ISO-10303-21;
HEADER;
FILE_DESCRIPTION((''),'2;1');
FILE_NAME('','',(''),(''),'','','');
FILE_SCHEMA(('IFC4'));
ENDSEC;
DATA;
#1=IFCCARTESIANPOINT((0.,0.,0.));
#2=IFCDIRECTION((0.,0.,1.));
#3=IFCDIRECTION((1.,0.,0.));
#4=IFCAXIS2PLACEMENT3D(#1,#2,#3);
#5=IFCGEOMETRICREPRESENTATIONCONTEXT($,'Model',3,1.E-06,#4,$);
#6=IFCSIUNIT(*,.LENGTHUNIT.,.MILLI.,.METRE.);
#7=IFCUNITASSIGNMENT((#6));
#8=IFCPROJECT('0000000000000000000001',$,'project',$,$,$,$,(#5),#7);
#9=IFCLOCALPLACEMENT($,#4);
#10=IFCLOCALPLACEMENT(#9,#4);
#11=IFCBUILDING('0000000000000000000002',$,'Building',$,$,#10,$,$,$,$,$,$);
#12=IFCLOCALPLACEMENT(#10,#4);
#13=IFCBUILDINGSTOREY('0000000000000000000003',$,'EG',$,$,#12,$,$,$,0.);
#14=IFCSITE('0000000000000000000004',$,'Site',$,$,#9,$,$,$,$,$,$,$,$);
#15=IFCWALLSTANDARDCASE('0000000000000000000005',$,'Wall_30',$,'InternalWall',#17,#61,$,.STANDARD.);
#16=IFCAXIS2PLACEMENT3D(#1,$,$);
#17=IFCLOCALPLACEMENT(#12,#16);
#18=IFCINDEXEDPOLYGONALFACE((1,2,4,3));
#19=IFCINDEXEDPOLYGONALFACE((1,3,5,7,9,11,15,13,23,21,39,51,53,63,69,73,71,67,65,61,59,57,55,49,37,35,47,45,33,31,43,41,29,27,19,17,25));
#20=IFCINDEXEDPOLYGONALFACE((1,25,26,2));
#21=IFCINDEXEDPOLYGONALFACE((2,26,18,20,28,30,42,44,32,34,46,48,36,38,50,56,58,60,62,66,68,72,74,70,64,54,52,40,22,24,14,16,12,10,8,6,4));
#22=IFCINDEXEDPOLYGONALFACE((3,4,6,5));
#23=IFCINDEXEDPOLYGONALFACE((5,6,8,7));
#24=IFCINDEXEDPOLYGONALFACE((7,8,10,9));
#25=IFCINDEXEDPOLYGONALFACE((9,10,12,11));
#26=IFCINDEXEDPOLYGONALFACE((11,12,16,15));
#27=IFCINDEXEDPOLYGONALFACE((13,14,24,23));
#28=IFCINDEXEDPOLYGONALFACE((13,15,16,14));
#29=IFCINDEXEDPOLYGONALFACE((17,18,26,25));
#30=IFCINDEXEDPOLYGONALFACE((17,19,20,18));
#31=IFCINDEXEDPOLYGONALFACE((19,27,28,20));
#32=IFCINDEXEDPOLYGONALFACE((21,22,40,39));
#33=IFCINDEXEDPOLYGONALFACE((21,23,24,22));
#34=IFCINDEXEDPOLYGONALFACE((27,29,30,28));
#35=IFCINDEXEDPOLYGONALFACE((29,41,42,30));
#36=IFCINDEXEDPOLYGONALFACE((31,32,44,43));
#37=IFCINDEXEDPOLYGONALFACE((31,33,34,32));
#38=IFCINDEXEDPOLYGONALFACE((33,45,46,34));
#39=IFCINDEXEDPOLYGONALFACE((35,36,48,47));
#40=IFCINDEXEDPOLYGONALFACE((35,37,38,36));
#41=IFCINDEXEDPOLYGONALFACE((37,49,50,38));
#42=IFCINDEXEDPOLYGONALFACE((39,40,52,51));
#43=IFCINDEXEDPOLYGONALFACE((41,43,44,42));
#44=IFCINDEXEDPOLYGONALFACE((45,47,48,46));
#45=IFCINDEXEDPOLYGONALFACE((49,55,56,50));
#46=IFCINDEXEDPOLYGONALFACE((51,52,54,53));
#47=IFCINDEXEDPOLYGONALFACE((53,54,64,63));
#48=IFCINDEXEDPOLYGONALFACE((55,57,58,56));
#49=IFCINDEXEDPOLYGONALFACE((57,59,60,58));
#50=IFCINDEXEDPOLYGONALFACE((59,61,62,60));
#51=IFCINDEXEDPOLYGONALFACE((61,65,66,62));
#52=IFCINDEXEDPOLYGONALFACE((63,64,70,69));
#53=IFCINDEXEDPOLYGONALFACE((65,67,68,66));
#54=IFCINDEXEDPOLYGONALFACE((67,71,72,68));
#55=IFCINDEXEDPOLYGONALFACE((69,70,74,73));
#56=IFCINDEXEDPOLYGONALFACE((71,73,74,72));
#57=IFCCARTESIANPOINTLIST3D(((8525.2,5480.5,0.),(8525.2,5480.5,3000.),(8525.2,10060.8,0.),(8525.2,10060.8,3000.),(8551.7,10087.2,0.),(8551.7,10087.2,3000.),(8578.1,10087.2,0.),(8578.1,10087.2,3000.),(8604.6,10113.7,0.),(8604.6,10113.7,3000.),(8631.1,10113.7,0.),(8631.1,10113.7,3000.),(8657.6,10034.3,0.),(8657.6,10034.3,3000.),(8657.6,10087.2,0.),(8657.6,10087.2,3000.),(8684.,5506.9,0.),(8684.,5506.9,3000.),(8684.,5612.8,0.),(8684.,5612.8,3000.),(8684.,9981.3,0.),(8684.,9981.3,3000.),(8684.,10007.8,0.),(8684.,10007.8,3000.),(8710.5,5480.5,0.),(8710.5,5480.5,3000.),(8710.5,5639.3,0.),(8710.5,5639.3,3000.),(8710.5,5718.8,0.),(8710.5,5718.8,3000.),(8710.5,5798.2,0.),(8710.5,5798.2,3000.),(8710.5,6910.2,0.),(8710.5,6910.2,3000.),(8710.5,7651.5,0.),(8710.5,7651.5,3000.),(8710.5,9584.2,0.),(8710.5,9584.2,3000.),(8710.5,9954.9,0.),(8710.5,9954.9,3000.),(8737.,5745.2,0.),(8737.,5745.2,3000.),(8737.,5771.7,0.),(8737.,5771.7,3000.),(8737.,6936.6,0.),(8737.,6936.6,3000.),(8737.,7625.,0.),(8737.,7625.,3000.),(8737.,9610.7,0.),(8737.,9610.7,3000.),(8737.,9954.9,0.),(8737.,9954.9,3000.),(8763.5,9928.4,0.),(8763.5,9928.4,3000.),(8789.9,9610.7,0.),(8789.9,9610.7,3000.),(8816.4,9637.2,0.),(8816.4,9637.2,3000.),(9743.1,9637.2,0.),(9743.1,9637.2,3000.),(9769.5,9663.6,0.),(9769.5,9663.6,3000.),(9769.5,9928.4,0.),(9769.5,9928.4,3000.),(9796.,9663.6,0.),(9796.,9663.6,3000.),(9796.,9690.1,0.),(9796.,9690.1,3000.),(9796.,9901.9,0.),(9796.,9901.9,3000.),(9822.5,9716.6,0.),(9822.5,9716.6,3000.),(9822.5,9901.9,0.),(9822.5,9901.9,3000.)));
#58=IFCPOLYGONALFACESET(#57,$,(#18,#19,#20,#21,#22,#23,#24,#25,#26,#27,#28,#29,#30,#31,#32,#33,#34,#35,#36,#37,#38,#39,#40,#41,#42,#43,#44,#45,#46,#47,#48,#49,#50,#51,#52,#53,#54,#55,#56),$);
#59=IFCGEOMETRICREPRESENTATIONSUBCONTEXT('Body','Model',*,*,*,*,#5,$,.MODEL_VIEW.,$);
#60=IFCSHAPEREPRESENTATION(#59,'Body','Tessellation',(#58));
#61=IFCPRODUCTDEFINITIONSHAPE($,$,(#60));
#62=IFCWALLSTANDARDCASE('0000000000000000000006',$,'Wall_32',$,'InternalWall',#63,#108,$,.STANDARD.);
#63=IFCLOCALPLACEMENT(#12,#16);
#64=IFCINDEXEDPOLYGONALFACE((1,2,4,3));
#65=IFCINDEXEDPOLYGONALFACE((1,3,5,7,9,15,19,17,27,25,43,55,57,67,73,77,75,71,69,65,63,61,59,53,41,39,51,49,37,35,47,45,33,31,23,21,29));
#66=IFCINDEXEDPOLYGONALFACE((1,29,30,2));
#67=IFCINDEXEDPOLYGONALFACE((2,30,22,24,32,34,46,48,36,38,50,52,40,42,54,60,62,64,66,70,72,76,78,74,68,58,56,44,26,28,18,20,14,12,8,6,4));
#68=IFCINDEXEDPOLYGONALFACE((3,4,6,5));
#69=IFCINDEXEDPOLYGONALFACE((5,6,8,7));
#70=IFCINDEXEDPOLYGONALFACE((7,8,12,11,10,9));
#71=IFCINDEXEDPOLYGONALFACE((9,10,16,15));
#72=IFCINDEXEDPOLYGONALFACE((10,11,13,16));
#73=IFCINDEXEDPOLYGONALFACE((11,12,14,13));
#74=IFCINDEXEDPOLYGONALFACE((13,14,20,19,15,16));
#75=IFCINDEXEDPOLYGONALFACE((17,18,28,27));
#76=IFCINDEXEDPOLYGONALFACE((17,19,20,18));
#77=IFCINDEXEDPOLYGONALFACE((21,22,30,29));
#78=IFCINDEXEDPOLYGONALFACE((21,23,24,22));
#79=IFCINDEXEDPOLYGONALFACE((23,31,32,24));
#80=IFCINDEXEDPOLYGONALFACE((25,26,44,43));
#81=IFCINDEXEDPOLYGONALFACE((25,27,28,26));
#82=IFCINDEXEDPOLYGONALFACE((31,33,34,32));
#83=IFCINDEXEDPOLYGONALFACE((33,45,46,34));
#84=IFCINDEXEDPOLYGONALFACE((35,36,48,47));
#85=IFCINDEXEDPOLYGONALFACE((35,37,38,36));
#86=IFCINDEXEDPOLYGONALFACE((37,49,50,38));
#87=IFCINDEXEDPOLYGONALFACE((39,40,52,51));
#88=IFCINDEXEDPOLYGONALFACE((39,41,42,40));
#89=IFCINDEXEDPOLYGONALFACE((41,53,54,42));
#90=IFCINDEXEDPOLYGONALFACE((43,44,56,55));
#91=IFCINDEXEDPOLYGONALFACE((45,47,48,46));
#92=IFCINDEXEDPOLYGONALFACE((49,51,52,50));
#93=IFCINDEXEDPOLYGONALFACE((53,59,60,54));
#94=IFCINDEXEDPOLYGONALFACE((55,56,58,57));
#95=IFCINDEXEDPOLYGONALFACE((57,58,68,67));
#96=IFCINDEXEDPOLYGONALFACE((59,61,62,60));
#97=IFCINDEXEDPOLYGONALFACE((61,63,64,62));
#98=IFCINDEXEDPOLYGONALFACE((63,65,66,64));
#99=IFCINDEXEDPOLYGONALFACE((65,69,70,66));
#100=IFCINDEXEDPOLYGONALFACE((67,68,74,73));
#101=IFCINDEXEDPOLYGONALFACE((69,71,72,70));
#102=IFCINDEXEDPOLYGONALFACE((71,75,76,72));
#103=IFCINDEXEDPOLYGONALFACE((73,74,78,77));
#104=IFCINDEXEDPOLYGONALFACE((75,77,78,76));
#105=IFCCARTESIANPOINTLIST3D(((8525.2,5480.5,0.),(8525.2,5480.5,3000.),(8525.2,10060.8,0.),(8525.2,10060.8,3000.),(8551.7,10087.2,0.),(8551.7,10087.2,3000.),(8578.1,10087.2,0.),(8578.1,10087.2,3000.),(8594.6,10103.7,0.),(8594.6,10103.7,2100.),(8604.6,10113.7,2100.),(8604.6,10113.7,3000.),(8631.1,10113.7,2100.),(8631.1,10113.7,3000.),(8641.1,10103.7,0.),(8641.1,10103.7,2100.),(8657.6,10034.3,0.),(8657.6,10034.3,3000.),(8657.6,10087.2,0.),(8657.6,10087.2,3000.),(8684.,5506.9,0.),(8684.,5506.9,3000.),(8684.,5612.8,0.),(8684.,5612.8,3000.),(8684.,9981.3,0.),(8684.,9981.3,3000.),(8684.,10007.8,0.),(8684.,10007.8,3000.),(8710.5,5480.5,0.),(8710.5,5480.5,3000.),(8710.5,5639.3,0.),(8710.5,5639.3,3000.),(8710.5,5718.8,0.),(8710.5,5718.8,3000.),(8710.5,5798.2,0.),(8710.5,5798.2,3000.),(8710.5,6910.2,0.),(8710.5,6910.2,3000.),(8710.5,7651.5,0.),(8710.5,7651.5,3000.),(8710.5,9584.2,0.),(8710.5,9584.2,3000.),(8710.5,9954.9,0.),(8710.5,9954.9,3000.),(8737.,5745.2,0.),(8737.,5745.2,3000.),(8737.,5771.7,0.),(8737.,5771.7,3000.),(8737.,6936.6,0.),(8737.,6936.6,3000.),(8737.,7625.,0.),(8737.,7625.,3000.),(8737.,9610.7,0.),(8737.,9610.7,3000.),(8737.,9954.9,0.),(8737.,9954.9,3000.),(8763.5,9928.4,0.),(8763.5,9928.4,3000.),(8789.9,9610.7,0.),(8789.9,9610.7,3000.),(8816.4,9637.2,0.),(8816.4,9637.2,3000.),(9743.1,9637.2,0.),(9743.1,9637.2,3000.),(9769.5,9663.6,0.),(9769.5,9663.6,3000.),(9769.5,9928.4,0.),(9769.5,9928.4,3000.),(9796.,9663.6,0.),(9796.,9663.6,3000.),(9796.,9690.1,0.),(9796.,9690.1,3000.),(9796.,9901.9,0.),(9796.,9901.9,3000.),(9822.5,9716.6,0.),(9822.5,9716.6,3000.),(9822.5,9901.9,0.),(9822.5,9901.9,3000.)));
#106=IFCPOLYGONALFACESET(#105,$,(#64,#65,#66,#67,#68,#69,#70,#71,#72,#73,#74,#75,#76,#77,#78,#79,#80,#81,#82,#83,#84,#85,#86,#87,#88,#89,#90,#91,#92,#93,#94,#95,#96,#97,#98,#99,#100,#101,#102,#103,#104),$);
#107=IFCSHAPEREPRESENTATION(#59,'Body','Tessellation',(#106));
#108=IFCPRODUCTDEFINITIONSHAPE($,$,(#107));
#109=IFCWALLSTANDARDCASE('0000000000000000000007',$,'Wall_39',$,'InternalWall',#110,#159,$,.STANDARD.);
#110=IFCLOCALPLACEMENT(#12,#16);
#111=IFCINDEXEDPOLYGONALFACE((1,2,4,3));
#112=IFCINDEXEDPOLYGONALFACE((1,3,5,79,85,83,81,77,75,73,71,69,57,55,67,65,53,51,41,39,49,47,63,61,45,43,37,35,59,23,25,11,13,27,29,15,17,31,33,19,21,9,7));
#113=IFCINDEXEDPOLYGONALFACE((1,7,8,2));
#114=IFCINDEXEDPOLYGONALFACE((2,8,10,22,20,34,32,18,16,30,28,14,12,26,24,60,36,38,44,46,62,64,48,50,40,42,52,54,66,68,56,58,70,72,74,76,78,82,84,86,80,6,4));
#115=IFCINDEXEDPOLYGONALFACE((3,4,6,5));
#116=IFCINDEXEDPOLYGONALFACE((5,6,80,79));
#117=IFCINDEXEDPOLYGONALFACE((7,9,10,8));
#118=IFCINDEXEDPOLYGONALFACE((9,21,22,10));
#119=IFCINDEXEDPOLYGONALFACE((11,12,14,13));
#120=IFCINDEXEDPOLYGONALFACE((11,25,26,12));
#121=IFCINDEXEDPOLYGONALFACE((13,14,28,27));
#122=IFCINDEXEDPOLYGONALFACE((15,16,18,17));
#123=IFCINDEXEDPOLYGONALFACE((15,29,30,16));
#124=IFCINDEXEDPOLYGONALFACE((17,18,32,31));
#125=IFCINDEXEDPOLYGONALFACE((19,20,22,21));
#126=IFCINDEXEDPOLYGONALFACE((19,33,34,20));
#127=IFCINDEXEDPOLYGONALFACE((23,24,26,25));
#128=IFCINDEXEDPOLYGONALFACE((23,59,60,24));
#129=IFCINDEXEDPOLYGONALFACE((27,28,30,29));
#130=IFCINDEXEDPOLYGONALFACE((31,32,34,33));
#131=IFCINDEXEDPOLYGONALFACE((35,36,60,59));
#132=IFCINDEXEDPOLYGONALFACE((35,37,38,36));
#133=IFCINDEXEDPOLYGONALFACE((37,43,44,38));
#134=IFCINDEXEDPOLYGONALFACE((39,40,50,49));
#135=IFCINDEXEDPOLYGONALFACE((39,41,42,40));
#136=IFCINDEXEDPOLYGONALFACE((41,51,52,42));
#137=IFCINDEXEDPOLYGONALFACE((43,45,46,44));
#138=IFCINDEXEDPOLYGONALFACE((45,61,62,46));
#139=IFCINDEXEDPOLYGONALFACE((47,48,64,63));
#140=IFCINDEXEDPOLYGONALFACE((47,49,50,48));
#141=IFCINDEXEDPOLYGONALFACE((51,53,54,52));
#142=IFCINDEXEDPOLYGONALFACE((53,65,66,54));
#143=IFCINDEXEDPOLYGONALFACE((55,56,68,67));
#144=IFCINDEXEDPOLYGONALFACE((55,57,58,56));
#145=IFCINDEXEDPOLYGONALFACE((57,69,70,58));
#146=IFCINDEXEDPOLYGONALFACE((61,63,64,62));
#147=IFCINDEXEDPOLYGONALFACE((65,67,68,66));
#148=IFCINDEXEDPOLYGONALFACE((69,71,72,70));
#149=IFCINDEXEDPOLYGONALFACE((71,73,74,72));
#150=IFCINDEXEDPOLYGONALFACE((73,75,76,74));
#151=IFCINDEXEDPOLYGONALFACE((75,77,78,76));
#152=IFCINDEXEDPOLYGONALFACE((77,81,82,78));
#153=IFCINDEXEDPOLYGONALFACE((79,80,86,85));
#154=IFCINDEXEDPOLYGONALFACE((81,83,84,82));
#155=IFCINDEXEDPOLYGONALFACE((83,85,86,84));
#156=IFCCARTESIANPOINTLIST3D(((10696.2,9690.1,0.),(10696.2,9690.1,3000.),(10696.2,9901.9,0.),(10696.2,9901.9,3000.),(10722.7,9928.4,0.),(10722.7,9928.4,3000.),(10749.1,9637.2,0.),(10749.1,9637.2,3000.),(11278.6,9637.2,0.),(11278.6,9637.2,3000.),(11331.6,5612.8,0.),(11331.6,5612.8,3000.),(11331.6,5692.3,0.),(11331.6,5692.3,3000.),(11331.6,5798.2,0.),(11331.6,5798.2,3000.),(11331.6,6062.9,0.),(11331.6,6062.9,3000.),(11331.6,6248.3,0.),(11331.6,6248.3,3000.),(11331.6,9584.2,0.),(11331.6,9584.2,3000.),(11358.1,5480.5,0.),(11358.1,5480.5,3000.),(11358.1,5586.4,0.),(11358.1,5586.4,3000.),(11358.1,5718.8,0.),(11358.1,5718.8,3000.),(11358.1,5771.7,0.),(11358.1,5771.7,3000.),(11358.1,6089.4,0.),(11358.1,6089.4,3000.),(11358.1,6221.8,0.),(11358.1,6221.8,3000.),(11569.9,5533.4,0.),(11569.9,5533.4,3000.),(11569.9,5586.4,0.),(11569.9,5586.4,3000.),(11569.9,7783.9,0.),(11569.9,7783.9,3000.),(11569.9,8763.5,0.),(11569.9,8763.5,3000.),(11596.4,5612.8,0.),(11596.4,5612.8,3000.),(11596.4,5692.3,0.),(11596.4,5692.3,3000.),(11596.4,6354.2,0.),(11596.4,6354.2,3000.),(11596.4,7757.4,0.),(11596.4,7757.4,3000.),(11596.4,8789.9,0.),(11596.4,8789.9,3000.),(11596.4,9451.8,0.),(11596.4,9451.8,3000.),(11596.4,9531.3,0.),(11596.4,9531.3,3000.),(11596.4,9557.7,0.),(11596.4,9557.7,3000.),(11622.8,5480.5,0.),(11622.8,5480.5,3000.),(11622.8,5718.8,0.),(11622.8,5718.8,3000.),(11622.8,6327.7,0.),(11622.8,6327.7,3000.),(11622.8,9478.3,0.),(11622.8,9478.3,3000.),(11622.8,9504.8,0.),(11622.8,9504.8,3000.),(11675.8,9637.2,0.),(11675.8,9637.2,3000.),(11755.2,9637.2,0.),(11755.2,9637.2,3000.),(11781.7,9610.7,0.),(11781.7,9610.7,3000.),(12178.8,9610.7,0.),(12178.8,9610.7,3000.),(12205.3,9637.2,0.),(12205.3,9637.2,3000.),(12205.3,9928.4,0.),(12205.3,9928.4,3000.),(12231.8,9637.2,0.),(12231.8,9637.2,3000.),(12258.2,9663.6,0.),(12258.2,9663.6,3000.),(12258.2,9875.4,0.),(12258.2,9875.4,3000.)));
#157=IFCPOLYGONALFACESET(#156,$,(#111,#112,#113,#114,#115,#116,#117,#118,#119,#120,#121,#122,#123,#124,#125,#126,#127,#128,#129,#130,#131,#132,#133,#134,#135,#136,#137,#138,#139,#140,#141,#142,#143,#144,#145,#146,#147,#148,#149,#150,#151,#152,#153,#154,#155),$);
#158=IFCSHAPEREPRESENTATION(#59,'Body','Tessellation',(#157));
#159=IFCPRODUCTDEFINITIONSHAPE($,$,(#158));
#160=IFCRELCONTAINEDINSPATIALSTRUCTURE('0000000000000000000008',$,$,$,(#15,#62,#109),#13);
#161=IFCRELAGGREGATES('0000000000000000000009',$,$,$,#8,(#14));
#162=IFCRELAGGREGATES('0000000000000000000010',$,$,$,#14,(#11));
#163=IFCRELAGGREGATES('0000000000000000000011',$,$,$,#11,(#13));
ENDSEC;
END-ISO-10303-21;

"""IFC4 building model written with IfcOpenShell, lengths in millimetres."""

from ifc_helpers import new_model, si_unit, frame, origin_with_axes, place, context, subcontext, project, spatial, polyline, rectangle, outline, extrude, element, save


model = new_model("IFC4")

# Units and contexts
model_context = context("Model", 3, precision=1e-06, world=origin_with_axes())
body_context = subcontext(model_context, "Body", "Model", "MODEL_VIEW")
ifc_project = project(units=[si_unit("LENGTHUNIT", "METRE", prefix="MILLI")], contexts=[model_context])

# Site, building, storey
site_placement = place(None, origin_with_axes())
site = spatial("IfcSite", under=ifc_project, at=site_placement, Name="Site")
building_placement = place(site_placement, origin_with_axes())
building = spatial("IfcBuilding", under=site, at=building_placement, Name="Building")
storey_placement = place(building_placement, origin_with_axes())
storey = spatial("IfcBuildingStorey", under=building, at=storey_placement, Name="EG", Elevation=0.0)

# Wall
for number, where, z_axis, x_axis, name in (
    (1, (0.0, 0.0, 0.0), (0.0, 0.0, 1.0), (1.0, 0.0, 0.0), "Wall_30"),
):
    element("IfcWallStandardCase", number, at=place(storey_placement, frame(where, z_axis=z_axis, x_axis=x_axis)), inside=storey, Name=name, ObjectType="InternalWall", PredefinedType="STANDARD", context=body_context, shape_type="SweptSolid", body=[
        extrude(outline(polyline([(8525.2, 5480.5, 0.0), (8525.2, 10060.8, 0.0), (8551.7, 10087.2, 0.0), (8578.1, 10087.2, 0.0), (8604.6, 10113.7, 0.0), (8631.1, 10113.7, 0.0), (8657.6, 10087.2, 0.0), (8657.6, 10034.3, 0.0), (8684.0, 10007.8, 0.0), (8684.0, 9981.3, 0.0), (8710.5, 9954.9, 0.0), (8737.0, 9954.9, 0.0), (8763.5, 9928.4, 0.0), (9769.5, 9928.4, 0.0), (9796.0, 9901.9, 0.0), (9822.5, 9901.9, 0.0), (9822.5, 9716.6, 0.0), (9796.0, 9690.1, 0.0), (9796.0, 9663.6, 0.0), (9769.5, 9663.6, 0.0), (9743.1, 9637.2, 0.0), (8816.4, 9637.2, 0.0), (8789.9, 9610.7, 0.0), (8737.0, 9610.7, 0.0), (8710.5, 9584.2, 0.0), (8710.5, 7651.5, 0.0), (8737.0, 7625.0, 0.0), (8737.0, 6936.6, 0.0), (8710.5, 6910.2, 0.0), (8710.5, 5798.2, 0.0), (8737.0, 5771.7, 0.0), (8737.0, 5745.2, 0.0), (8710.5, 5718.8, 0.0), (8710.5, 5639.3, 0.0), (8684.0, 5612.8, 0.0), (8684.0, 5506.9, 0.0), (8710.5, 5480.5, 0.0), (8525.2, 5480.5, 0.0)])), origin_with_axes(), (0.0, 0.0, 1.0), 3000.0),
    ])

# Wall, opening
wall_1_placement = place(storey_placement, origin_with_axes())
wall_1 = element("IfcWallStandardCase", 2, at=wall_1_placement, inside=storey, Name="Wall_32", ObjectType="InternalWall", PredefinedType="STANDARD", context=body_context, shape_type="SweptSolid", body=[
    extrude(outline(polyline([(8525.2, 5480.5, 0.0), (8525.2, 10060.8, 0.0), (8551.7, 10087.2, 0.0), (8578.1, 10087.2, 0.0), (8604.6, 10113.7, 0.0), (8631.1, 10113.7, 0.0), (8657.6, 10087.2, 0.0), (8657.6, 10034.3, 0.0), (8684.0, 10007.8, 0.0), (8684.0, 9981.3, 0.0), (8710.5, 9954.9, 0.0), (8737.0, 9954.9, 0.0), (8763.5, 9928.4, 0.0), (9769.5, 9928.4, 0.0), (9796.0, 9901.9, 0.0), (9822.5, 9901.9, 0.0), (9822.5, 9716.6, 0.0), (9796.0, 9690.1, 0.0), (9796.0, 9663.6, 0.0), (9769.5, 9663.6, 0.0), (9743.1, 9637.2, 0.0), (8816.4, 9637.2, 0.0), (8789.9, 9610.7, 0.0), (8737.0, 9610.7, 0.0), (8710.5, 9584.2, 0.0), (8710.5, 7651.5, 0.0), (8737.0, 7625.0, 0.0), (8737.0, 6936.6, 0.0), (8710.5, 6910.2, 0.0), (8710.5, 5798.2, 0.0), (8737.0, 5771.7, 0.0), (8737.0, 5745.2, 0.0), (8710.5, 5718.8, 0.0), (8710.5, 5639.3, 0.0), (8684.0, 5612.8, 0.0), (8684.0, 5506.9, 0.0), (8710.5, 5480.5, 0.0), (8525.2, 5480.5, 0.0)])), origin_with_axes(), (0.0, 0.0, 1.0), 3000.0),
])
opening_1_placement = place(wall_1_placement, origin_with_axes())
element("IfcOpeningElement", 3, at=opening_1_placement, inside=storey, cuts=wall_1, context=body_context, shape_type="SweptSolid", body=[
    extrude(rectangle(XDim=1138.5, YDim=240.0), frame((8697.4, 10672.9, 0.0), z_axis=(0.0, 0.0, 1.0), x_axis=(0.0, 1.0, 0.0)), (0.0, 0.0, 1.0), 2100.0),
])

# Wall
wall_2_placement = place(storey_placement, origin_with_axes())
element("IfcWallStandardCase", 4, at=wall_2_placement, inside=storey, Name="Wall_39", ObjectType="InternalWall", PredefinedType="STANDARD", context=body_context, shape_type="SweptSolid", body=[
    extrude(outline(polyline([(11358.1, 5480.5, 0.0), (11358.1, 5586.4, 0.0), (11331.6, 5612.8, 0.0), (11331.6, 5692.3, 0.0), (11358.1, 5718.8, 0.0), (11358.1, 5771.7, 0.0), (11331.6, 5798.2, 0.0), (11331.6, 6062.9, 0.0), (11358.1, 6089.4, 0.0), (11358.1, 6221.8, 0.0), (11331.6, 6248.3, 0.0), (11331.6, 9584.2, 0.0), (11278.6, 9637.2, 0.0), (10749.1, 9637.2, 0.0), (10696.2, 9690.1, 0.0), (10696.2, 9901.9, 0.0), (10722.7, 9928.4, 0.0), (12205.3, 9928.4, 0.0), (12258.2, 9875.4, 0.0), (12258.2, 9663.6, 0.0), (12231.8, 9637.2, 0.0), (12205.3, 9637.2, 0.0), (12178.8, 9610.7, 0.0), (11781.7, 9610.7, 0.0), (11755.2, 9637.2, 0.0), (11675.8, 9637.2, 0.0), (11596.4, 9557.7, 0.0), (11596.4, 9531.3, 0.0), (11622.8, 9504.8, 0.0), (11622.8, 9478.3, 0.0), (11596.4, 9451.8, 0.0), (11596.4, 8789.9, 0.0), (11569.9, 8763.5, 0.0), (11569.9, 7783.9, 0.0), (11596.4, 7757.4, 0.0), (11596.4, 6354.2, 0.0), (11622.8, 6327.7, 0.0), (11622.8, 5718.8, 0.0), (11596.4, 5692.3, 0.0), (11596.4, 5612.8, 0.0), (11569.9, 5586.4, 0.0), (11569.9, 5533.4, 0.0), (11622.8, 5480.5, 0.0), (11755.2, 5480.5, 0.0), (11358.1, 5480.5, 0.0)])), origin_with_axes(), (0.0, 0.0, 1.0), 3000.0),
])

save(model, "model.ifc")
